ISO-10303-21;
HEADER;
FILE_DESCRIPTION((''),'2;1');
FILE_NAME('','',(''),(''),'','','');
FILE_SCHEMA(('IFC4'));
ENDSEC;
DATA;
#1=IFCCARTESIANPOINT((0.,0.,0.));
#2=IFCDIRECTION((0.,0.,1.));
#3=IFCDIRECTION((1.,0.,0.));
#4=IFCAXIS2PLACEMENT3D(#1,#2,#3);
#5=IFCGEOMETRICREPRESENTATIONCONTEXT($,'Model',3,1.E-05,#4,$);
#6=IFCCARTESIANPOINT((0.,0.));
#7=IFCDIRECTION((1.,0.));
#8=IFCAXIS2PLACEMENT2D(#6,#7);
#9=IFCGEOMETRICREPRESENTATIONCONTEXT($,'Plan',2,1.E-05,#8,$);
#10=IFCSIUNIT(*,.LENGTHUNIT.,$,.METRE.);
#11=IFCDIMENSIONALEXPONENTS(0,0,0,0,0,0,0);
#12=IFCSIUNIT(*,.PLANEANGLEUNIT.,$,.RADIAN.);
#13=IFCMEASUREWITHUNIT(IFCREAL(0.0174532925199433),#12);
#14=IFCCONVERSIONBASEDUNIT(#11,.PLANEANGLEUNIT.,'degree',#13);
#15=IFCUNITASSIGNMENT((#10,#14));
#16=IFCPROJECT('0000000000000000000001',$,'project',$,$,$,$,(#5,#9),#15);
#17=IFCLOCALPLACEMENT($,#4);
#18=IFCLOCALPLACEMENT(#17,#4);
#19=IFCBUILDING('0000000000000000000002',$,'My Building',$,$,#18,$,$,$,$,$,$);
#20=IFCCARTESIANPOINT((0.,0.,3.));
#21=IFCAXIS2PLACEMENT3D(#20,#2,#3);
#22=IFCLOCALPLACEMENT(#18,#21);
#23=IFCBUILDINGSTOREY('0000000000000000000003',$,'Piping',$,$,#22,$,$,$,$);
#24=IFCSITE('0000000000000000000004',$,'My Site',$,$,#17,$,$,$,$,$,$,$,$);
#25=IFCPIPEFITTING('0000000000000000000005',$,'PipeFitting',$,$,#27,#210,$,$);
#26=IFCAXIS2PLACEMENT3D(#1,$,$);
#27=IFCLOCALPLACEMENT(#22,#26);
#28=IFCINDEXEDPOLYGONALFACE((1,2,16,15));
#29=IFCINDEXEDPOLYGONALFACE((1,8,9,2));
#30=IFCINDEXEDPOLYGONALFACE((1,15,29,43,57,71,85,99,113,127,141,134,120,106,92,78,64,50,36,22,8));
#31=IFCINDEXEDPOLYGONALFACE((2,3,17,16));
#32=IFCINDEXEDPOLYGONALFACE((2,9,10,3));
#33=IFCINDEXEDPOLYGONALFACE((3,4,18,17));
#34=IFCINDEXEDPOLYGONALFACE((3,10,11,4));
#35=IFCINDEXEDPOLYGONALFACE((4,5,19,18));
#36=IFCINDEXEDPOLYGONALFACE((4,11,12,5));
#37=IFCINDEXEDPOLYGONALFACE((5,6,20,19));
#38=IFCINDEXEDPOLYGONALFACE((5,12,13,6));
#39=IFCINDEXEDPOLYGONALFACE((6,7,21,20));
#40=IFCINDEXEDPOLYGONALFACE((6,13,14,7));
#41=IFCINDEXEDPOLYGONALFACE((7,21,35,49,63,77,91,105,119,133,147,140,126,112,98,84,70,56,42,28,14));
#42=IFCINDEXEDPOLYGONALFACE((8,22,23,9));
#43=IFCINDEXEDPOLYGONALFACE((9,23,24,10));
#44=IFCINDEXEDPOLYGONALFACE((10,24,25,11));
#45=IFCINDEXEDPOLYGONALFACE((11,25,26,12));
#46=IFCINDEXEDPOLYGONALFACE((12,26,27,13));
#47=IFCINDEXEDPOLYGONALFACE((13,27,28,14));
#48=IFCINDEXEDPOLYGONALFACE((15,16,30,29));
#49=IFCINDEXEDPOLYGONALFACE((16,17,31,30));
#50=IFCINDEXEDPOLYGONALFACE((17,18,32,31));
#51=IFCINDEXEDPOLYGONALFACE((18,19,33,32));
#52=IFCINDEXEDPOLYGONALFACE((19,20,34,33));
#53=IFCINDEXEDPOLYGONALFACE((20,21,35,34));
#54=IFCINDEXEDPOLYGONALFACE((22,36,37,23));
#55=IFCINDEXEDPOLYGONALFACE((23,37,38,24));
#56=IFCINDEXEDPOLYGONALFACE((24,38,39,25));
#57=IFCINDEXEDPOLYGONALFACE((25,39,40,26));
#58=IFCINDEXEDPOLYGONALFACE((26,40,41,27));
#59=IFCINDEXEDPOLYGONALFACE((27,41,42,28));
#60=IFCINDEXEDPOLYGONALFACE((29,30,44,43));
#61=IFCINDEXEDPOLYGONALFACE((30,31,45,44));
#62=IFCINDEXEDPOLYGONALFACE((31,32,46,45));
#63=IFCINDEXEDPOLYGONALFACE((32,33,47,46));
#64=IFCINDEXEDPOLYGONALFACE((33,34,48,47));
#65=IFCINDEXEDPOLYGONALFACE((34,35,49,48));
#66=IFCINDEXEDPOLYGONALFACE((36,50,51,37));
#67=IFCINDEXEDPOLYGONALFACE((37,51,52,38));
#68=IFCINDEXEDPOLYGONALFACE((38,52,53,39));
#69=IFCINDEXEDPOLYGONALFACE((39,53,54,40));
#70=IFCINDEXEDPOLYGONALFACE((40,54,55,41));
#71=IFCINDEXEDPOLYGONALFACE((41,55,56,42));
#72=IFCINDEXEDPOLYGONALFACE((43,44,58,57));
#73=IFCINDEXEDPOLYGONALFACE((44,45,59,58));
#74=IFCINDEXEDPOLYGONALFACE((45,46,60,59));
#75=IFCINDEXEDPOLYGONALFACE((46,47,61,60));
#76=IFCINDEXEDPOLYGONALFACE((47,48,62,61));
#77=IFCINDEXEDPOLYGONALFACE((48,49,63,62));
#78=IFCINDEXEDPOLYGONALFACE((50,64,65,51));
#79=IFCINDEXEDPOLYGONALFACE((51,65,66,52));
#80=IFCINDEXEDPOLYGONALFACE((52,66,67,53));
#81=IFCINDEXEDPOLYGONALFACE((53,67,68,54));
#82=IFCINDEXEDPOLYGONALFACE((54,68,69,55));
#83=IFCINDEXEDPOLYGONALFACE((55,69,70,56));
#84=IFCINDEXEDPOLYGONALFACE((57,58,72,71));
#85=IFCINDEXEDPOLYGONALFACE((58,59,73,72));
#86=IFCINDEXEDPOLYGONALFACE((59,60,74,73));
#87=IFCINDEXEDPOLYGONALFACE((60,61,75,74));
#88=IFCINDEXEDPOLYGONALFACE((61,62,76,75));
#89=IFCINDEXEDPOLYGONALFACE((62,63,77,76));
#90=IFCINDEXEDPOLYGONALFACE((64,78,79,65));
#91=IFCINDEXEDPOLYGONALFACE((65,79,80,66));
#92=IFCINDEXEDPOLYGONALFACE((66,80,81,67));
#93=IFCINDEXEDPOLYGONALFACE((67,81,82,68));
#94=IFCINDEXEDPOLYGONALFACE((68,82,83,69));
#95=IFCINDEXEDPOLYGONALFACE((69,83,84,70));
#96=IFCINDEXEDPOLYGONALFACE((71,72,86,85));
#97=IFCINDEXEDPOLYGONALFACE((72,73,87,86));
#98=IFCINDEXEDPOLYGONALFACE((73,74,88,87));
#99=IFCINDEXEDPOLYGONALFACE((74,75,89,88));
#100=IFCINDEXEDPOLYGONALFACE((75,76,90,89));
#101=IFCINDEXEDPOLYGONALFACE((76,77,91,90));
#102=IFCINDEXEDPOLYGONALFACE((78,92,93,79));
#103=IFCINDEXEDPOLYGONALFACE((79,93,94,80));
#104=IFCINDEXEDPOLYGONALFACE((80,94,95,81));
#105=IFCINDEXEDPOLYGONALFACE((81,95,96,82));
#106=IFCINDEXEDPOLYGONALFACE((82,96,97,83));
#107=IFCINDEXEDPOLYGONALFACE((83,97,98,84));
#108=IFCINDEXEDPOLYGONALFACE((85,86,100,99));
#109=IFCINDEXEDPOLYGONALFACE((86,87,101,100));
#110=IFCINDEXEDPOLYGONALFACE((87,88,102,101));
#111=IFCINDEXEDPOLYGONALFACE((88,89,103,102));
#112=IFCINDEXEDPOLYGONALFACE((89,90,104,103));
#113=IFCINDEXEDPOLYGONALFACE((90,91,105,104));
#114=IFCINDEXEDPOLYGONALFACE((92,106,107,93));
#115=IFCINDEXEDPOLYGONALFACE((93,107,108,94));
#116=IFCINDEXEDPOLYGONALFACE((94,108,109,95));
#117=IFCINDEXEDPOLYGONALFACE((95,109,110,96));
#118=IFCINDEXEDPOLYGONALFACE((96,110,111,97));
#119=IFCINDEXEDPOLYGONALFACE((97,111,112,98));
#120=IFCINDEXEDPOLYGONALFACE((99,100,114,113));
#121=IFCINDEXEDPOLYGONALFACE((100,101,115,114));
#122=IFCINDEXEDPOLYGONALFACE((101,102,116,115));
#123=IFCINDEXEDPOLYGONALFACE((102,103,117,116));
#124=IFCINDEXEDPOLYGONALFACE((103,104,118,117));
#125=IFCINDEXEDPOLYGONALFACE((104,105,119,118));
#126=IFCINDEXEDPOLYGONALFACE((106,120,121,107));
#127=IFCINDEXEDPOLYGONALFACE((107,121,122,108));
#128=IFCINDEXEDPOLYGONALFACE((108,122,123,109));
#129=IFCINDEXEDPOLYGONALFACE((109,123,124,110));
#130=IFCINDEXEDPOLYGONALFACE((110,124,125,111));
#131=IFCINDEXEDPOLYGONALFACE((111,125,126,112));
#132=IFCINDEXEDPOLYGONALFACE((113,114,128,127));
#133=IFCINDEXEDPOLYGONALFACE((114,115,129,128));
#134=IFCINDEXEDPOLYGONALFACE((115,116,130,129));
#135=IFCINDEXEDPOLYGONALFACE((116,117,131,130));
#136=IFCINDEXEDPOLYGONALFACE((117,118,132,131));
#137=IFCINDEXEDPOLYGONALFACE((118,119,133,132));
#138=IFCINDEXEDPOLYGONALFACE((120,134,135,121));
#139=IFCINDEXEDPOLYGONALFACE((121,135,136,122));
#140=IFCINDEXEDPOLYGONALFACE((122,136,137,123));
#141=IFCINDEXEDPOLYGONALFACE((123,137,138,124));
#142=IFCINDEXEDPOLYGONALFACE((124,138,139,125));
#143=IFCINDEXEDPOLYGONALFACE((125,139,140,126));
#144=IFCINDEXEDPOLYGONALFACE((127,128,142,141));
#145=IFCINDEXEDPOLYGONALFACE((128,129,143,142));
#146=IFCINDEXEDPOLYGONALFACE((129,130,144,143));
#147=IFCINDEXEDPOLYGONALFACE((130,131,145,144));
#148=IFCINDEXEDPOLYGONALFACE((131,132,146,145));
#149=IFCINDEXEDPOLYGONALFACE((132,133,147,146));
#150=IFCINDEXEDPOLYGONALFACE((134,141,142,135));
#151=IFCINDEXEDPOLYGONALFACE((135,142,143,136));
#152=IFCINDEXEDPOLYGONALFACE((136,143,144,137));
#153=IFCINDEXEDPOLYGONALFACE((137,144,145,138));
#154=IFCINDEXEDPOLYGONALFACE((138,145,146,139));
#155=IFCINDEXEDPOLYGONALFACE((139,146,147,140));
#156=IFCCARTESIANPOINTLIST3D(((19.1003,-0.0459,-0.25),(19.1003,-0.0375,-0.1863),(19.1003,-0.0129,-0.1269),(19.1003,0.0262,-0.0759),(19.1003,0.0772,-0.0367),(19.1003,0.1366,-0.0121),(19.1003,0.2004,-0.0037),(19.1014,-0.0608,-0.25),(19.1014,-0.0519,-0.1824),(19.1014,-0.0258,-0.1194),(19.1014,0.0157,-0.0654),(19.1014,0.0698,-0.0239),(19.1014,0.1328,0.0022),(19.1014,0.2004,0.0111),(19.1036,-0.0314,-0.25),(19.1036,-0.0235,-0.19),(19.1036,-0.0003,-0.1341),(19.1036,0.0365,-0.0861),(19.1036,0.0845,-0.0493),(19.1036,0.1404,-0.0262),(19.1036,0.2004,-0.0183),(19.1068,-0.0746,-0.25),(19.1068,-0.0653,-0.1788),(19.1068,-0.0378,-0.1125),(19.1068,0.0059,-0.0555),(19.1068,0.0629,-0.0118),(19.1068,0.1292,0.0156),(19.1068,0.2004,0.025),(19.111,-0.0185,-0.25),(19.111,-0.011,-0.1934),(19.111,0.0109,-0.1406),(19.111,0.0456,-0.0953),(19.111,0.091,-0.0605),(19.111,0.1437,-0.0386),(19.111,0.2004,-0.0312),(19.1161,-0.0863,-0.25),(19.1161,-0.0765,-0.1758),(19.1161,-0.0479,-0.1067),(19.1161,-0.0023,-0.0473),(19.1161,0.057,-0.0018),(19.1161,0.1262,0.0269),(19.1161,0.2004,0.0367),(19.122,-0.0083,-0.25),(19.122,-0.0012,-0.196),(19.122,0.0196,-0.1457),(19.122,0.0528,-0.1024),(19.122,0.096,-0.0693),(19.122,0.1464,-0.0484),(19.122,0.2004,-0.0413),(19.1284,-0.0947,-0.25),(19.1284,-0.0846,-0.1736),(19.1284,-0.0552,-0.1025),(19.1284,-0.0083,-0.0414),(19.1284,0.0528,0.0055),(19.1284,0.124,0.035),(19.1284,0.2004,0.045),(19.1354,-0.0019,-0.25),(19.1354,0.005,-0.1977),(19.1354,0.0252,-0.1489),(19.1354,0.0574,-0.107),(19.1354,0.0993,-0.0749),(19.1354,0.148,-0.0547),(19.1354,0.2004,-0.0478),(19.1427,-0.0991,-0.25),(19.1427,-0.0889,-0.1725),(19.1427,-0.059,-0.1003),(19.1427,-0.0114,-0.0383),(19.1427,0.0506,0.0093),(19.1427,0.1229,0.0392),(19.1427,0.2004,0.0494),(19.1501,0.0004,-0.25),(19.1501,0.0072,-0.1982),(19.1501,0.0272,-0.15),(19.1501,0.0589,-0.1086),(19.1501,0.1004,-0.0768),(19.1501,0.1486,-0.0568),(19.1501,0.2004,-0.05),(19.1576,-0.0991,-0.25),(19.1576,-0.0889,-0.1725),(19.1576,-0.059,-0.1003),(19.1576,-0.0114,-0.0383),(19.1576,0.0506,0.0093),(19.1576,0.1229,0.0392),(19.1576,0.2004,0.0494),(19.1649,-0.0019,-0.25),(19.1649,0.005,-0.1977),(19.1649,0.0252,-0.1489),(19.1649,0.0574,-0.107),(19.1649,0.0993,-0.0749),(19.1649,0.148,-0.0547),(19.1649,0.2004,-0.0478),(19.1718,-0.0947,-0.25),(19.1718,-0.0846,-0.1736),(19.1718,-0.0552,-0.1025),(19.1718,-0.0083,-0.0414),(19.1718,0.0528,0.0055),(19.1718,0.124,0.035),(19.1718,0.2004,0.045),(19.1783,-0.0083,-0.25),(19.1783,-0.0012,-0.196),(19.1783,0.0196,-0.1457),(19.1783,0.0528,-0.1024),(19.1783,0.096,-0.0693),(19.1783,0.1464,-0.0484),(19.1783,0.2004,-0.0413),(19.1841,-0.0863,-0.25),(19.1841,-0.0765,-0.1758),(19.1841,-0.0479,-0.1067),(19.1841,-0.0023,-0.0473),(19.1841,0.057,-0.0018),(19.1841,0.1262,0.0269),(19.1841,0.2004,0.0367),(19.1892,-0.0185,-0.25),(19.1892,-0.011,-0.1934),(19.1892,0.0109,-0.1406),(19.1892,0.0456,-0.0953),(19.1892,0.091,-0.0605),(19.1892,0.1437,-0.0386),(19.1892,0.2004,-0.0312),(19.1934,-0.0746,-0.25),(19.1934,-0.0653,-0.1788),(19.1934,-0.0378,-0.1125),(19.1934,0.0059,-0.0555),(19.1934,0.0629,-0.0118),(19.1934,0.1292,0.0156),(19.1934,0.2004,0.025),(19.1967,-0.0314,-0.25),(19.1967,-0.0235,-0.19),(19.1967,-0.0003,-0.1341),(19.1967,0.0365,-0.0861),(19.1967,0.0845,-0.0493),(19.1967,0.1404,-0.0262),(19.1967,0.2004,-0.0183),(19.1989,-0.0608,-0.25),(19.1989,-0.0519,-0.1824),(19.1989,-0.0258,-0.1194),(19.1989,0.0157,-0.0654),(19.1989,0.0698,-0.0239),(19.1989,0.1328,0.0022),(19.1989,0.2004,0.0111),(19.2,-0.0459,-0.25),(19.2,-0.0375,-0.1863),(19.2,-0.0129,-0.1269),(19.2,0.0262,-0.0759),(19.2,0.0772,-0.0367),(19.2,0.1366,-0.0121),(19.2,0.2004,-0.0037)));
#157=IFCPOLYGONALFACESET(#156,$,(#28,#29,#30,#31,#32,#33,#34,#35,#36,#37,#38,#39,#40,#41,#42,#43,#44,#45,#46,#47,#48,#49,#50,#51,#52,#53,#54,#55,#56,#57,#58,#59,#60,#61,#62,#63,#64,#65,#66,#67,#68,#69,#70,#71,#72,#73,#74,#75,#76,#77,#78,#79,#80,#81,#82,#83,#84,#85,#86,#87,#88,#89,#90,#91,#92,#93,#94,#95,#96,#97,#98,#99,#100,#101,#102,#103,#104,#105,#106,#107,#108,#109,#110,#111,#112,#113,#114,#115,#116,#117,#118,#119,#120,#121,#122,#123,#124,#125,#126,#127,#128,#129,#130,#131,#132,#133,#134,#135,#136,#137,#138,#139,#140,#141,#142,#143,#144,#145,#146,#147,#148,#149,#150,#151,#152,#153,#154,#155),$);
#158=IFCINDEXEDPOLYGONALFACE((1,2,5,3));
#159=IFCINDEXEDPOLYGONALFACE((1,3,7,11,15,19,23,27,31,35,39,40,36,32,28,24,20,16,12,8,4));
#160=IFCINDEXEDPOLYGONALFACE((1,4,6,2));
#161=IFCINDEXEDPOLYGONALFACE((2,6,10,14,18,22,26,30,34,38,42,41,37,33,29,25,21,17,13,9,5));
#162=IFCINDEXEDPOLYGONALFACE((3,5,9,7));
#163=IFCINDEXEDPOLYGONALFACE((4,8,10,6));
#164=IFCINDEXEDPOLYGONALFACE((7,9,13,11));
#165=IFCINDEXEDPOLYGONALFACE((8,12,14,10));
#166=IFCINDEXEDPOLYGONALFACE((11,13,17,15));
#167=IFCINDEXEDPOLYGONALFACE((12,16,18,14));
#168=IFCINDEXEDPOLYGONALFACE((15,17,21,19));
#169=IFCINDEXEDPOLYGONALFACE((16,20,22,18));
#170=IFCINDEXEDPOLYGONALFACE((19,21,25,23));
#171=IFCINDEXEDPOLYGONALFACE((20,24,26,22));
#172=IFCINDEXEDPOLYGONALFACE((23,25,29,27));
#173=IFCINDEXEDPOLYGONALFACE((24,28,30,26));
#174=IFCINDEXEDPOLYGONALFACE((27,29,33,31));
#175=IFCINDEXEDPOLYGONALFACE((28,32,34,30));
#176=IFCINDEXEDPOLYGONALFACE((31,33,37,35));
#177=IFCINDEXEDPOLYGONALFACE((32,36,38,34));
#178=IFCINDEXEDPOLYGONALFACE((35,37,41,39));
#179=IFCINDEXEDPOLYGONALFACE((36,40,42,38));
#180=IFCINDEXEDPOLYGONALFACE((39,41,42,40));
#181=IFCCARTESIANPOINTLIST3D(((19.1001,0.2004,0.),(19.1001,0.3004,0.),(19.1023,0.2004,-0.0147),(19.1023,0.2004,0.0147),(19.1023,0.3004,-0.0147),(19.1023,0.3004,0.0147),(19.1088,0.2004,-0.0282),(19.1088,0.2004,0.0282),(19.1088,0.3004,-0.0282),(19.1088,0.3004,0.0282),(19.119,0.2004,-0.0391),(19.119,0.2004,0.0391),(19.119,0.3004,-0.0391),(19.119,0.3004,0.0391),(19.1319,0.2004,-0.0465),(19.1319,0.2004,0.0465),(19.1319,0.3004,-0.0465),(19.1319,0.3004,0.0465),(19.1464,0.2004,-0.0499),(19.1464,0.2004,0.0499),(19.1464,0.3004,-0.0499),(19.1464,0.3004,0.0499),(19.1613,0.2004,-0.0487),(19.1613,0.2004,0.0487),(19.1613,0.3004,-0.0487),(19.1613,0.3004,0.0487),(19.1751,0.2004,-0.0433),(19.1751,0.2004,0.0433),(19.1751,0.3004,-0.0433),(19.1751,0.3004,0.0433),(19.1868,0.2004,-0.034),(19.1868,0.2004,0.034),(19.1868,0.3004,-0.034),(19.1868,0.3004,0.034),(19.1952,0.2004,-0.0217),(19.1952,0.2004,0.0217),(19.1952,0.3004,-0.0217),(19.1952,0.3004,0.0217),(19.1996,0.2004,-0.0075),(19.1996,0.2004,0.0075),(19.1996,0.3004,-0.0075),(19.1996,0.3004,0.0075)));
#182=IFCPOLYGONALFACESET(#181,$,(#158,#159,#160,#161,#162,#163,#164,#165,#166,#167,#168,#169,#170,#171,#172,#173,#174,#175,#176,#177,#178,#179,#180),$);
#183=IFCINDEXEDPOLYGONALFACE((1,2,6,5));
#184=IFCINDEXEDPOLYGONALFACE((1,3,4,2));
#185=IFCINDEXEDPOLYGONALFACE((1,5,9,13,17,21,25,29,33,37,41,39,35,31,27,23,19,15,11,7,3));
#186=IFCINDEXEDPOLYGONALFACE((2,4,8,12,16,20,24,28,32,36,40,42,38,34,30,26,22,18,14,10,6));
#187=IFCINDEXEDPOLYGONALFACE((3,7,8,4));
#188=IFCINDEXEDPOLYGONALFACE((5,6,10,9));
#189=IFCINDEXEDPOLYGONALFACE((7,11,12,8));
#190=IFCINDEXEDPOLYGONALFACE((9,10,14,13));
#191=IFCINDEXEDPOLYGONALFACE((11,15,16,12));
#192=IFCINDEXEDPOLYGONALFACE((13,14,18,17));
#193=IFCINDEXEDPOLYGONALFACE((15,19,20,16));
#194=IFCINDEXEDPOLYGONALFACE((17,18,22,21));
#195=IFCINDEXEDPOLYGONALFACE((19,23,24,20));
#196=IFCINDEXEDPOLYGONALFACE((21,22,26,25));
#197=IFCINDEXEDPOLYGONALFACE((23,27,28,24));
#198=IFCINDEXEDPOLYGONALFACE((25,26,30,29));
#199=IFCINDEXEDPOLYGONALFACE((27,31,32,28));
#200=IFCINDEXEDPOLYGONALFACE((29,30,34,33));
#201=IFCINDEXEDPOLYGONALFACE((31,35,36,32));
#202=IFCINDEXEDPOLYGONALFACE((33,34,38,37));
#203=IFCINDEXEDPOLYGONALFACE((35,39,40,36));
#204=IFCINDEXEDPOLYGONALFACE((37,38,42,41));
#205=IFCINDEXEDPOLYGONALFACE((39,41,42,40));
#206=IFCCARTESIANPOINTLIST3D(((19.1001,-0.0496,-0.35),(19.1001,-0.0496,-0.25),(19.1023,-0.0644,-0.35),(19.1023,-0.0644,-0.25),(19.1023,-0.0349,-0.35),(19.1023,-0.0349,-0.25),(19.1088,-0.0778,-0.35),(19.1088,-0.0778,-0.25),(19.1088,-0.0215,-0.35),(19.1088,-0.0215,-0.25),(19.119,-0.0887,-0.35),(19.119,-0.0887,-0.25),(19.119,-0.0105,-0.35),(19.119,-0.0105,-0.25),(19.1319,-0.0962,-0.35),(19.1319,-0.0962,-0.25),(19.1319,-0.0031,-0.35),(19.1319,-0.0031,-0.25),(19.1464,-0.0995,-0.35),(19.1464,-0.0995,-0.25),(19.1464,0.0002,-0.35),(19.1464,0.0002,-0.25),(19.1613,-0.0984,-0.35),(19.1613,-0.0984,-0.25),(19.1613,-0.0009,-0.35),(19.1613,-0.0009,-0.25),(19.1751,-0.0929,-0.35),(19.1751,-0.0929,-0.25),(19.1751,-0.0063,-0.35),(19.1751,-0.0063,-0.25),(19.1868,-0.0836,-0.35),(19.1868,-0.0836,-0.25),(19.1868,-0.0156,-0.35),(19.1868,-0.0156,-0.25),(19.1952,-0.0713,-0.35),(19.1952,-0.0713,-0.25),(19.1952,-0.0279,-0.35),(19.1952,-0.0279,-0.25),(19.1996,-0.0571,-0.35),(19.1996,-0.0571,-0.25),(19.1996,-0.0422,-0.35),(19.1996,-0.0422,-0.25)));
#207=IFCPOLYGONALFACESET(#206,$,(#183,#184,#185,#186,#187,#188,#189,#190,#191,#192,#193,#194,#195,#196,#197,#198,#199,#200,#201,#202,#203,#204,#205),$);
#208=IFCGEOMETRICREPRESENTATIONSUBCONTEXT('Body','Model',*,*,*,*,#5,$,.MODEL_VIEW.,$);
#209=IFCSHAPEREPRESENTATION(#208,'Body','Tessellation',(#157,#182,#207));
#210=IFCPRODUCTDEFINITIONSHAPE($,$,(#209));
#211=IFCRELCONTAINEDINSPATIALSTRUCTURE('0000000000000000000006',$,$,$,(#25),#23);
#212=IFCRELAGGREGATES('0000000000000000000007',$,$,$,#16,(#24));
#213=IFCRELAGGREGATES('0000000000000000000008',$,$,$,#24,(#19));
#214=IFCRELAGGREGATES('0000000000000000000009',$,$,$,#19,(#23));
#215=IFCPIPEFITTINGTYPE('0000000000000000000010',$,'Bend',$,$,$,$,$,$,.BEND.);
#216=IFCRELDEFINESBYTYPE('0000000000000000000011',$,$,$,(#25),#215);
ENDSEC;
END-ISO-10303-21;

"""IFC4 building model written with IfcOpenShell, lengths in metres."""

from ifc_helpers import new_model, entity, si_unit, converted_unit, frame, origin_with_axes, origin_2d_with_axis, place, context, subcontext, project, spatial, circle, extrude, source, transform, mapped, type_object, type_shapes, element, save


model = new_model("IFC4")

# Units and contexts
model_context = context("Model", 3, precision=1e-05, world=origin_with_axes())
plan_context = context("Plan", 2, precision=1e-05, world=origin_2d_with_axis())
body_context = subcontext(model_context, "Body", "Model", "MODEL_VIEW")
ifc_project = project(units=[si_unit("LENGTHUNIT", "METRE"), converted_unit("PLANEANGLEUNIT", "degree", entity("IfcReal", 0.0174532925199433), si_unit("PLANEANGLEUNIT", "RADIAN"), dimensions=[0, 0, 0, 0, 0, 0, 0])], contexts=[model_context, plan_context])

# Site, building, storey
site_placement = place(None, origin_with_axes())
site = spatial("IfcSite", under=ifc_project, at=site_placement, Name="My Site")
building_placement = place(site_placement, origin_with_axes())
building = spatial("IfcBuilding", under=site, at=building_placement, Name="My Building")
storey_placement = place(building_placement, frame((0.0, 0.0, 3.0), z_axis=(0.0, 0.0, 1.0), x_axis=(1.0, 0.0, 0.0)))
storey = spatial("IfcBuildingStorey", under=building, at=storey_placement, Name="Piping")

# Pipe fitting
pipe_fitting_type = type_object("IfcPipeFittingType", Name="Bend", PredefinedType="BEND")
shared_shape = source(origin_with_axes(), body_context, "Body", "SolidModel", [
    entity("IfcSweptDiskSolid", entity("IfcIndexedPolyCurve", entity("IfcCartesianPointList3D", [[0.0, 0.0, -0.1], [0.0, -0.0732, -0.2768], [0.0, -0.25, -0.35]]), [entity("IfcArcIndex", [1, 2, 3])]), 0.05),
    extrude(circle(Radius=0.05), origin_with_axes(), (0.0, 0.0, -1.0), 0.1),
    extrude(circle(Radius=0.05), frame((0.0, -0.25, -0.35), z_axis=(0.0, -1.0, 0.0), x_axis=(1.0, 0.0, 0.0)), (0.0, 0.0, 1.0), 0.1),
])
type_shapes(pipe_fitting_type, [shared_shape])
for number, where, z_axis, x_axis, name in (
    (1, (19.1501, 0.3004, 0.0), (0.0, 1.0, 0.0), (-1.0, 0.0, 0.0), "PipeFitting"),
):
    element("IfcPipeFitting", number, at=place(storey_placement, frame(where, z_axis=z_axis, x_axis=x_axis)), inside=storey, type_object=pipe_fitting_type, Name=name, context=body_context, shape_type="MappedRepresentation", body=[
        mapped(shared_shape, transform((0.0, 0.0, 0.0), x_axis=(1.0, 0.0, 0.0), y_axis=(0.0, 1.0, 0.0), z_axis=(0.0, 0.0, 1.0), scale=1.0)),
    ])

save(model, "model.ifc")
